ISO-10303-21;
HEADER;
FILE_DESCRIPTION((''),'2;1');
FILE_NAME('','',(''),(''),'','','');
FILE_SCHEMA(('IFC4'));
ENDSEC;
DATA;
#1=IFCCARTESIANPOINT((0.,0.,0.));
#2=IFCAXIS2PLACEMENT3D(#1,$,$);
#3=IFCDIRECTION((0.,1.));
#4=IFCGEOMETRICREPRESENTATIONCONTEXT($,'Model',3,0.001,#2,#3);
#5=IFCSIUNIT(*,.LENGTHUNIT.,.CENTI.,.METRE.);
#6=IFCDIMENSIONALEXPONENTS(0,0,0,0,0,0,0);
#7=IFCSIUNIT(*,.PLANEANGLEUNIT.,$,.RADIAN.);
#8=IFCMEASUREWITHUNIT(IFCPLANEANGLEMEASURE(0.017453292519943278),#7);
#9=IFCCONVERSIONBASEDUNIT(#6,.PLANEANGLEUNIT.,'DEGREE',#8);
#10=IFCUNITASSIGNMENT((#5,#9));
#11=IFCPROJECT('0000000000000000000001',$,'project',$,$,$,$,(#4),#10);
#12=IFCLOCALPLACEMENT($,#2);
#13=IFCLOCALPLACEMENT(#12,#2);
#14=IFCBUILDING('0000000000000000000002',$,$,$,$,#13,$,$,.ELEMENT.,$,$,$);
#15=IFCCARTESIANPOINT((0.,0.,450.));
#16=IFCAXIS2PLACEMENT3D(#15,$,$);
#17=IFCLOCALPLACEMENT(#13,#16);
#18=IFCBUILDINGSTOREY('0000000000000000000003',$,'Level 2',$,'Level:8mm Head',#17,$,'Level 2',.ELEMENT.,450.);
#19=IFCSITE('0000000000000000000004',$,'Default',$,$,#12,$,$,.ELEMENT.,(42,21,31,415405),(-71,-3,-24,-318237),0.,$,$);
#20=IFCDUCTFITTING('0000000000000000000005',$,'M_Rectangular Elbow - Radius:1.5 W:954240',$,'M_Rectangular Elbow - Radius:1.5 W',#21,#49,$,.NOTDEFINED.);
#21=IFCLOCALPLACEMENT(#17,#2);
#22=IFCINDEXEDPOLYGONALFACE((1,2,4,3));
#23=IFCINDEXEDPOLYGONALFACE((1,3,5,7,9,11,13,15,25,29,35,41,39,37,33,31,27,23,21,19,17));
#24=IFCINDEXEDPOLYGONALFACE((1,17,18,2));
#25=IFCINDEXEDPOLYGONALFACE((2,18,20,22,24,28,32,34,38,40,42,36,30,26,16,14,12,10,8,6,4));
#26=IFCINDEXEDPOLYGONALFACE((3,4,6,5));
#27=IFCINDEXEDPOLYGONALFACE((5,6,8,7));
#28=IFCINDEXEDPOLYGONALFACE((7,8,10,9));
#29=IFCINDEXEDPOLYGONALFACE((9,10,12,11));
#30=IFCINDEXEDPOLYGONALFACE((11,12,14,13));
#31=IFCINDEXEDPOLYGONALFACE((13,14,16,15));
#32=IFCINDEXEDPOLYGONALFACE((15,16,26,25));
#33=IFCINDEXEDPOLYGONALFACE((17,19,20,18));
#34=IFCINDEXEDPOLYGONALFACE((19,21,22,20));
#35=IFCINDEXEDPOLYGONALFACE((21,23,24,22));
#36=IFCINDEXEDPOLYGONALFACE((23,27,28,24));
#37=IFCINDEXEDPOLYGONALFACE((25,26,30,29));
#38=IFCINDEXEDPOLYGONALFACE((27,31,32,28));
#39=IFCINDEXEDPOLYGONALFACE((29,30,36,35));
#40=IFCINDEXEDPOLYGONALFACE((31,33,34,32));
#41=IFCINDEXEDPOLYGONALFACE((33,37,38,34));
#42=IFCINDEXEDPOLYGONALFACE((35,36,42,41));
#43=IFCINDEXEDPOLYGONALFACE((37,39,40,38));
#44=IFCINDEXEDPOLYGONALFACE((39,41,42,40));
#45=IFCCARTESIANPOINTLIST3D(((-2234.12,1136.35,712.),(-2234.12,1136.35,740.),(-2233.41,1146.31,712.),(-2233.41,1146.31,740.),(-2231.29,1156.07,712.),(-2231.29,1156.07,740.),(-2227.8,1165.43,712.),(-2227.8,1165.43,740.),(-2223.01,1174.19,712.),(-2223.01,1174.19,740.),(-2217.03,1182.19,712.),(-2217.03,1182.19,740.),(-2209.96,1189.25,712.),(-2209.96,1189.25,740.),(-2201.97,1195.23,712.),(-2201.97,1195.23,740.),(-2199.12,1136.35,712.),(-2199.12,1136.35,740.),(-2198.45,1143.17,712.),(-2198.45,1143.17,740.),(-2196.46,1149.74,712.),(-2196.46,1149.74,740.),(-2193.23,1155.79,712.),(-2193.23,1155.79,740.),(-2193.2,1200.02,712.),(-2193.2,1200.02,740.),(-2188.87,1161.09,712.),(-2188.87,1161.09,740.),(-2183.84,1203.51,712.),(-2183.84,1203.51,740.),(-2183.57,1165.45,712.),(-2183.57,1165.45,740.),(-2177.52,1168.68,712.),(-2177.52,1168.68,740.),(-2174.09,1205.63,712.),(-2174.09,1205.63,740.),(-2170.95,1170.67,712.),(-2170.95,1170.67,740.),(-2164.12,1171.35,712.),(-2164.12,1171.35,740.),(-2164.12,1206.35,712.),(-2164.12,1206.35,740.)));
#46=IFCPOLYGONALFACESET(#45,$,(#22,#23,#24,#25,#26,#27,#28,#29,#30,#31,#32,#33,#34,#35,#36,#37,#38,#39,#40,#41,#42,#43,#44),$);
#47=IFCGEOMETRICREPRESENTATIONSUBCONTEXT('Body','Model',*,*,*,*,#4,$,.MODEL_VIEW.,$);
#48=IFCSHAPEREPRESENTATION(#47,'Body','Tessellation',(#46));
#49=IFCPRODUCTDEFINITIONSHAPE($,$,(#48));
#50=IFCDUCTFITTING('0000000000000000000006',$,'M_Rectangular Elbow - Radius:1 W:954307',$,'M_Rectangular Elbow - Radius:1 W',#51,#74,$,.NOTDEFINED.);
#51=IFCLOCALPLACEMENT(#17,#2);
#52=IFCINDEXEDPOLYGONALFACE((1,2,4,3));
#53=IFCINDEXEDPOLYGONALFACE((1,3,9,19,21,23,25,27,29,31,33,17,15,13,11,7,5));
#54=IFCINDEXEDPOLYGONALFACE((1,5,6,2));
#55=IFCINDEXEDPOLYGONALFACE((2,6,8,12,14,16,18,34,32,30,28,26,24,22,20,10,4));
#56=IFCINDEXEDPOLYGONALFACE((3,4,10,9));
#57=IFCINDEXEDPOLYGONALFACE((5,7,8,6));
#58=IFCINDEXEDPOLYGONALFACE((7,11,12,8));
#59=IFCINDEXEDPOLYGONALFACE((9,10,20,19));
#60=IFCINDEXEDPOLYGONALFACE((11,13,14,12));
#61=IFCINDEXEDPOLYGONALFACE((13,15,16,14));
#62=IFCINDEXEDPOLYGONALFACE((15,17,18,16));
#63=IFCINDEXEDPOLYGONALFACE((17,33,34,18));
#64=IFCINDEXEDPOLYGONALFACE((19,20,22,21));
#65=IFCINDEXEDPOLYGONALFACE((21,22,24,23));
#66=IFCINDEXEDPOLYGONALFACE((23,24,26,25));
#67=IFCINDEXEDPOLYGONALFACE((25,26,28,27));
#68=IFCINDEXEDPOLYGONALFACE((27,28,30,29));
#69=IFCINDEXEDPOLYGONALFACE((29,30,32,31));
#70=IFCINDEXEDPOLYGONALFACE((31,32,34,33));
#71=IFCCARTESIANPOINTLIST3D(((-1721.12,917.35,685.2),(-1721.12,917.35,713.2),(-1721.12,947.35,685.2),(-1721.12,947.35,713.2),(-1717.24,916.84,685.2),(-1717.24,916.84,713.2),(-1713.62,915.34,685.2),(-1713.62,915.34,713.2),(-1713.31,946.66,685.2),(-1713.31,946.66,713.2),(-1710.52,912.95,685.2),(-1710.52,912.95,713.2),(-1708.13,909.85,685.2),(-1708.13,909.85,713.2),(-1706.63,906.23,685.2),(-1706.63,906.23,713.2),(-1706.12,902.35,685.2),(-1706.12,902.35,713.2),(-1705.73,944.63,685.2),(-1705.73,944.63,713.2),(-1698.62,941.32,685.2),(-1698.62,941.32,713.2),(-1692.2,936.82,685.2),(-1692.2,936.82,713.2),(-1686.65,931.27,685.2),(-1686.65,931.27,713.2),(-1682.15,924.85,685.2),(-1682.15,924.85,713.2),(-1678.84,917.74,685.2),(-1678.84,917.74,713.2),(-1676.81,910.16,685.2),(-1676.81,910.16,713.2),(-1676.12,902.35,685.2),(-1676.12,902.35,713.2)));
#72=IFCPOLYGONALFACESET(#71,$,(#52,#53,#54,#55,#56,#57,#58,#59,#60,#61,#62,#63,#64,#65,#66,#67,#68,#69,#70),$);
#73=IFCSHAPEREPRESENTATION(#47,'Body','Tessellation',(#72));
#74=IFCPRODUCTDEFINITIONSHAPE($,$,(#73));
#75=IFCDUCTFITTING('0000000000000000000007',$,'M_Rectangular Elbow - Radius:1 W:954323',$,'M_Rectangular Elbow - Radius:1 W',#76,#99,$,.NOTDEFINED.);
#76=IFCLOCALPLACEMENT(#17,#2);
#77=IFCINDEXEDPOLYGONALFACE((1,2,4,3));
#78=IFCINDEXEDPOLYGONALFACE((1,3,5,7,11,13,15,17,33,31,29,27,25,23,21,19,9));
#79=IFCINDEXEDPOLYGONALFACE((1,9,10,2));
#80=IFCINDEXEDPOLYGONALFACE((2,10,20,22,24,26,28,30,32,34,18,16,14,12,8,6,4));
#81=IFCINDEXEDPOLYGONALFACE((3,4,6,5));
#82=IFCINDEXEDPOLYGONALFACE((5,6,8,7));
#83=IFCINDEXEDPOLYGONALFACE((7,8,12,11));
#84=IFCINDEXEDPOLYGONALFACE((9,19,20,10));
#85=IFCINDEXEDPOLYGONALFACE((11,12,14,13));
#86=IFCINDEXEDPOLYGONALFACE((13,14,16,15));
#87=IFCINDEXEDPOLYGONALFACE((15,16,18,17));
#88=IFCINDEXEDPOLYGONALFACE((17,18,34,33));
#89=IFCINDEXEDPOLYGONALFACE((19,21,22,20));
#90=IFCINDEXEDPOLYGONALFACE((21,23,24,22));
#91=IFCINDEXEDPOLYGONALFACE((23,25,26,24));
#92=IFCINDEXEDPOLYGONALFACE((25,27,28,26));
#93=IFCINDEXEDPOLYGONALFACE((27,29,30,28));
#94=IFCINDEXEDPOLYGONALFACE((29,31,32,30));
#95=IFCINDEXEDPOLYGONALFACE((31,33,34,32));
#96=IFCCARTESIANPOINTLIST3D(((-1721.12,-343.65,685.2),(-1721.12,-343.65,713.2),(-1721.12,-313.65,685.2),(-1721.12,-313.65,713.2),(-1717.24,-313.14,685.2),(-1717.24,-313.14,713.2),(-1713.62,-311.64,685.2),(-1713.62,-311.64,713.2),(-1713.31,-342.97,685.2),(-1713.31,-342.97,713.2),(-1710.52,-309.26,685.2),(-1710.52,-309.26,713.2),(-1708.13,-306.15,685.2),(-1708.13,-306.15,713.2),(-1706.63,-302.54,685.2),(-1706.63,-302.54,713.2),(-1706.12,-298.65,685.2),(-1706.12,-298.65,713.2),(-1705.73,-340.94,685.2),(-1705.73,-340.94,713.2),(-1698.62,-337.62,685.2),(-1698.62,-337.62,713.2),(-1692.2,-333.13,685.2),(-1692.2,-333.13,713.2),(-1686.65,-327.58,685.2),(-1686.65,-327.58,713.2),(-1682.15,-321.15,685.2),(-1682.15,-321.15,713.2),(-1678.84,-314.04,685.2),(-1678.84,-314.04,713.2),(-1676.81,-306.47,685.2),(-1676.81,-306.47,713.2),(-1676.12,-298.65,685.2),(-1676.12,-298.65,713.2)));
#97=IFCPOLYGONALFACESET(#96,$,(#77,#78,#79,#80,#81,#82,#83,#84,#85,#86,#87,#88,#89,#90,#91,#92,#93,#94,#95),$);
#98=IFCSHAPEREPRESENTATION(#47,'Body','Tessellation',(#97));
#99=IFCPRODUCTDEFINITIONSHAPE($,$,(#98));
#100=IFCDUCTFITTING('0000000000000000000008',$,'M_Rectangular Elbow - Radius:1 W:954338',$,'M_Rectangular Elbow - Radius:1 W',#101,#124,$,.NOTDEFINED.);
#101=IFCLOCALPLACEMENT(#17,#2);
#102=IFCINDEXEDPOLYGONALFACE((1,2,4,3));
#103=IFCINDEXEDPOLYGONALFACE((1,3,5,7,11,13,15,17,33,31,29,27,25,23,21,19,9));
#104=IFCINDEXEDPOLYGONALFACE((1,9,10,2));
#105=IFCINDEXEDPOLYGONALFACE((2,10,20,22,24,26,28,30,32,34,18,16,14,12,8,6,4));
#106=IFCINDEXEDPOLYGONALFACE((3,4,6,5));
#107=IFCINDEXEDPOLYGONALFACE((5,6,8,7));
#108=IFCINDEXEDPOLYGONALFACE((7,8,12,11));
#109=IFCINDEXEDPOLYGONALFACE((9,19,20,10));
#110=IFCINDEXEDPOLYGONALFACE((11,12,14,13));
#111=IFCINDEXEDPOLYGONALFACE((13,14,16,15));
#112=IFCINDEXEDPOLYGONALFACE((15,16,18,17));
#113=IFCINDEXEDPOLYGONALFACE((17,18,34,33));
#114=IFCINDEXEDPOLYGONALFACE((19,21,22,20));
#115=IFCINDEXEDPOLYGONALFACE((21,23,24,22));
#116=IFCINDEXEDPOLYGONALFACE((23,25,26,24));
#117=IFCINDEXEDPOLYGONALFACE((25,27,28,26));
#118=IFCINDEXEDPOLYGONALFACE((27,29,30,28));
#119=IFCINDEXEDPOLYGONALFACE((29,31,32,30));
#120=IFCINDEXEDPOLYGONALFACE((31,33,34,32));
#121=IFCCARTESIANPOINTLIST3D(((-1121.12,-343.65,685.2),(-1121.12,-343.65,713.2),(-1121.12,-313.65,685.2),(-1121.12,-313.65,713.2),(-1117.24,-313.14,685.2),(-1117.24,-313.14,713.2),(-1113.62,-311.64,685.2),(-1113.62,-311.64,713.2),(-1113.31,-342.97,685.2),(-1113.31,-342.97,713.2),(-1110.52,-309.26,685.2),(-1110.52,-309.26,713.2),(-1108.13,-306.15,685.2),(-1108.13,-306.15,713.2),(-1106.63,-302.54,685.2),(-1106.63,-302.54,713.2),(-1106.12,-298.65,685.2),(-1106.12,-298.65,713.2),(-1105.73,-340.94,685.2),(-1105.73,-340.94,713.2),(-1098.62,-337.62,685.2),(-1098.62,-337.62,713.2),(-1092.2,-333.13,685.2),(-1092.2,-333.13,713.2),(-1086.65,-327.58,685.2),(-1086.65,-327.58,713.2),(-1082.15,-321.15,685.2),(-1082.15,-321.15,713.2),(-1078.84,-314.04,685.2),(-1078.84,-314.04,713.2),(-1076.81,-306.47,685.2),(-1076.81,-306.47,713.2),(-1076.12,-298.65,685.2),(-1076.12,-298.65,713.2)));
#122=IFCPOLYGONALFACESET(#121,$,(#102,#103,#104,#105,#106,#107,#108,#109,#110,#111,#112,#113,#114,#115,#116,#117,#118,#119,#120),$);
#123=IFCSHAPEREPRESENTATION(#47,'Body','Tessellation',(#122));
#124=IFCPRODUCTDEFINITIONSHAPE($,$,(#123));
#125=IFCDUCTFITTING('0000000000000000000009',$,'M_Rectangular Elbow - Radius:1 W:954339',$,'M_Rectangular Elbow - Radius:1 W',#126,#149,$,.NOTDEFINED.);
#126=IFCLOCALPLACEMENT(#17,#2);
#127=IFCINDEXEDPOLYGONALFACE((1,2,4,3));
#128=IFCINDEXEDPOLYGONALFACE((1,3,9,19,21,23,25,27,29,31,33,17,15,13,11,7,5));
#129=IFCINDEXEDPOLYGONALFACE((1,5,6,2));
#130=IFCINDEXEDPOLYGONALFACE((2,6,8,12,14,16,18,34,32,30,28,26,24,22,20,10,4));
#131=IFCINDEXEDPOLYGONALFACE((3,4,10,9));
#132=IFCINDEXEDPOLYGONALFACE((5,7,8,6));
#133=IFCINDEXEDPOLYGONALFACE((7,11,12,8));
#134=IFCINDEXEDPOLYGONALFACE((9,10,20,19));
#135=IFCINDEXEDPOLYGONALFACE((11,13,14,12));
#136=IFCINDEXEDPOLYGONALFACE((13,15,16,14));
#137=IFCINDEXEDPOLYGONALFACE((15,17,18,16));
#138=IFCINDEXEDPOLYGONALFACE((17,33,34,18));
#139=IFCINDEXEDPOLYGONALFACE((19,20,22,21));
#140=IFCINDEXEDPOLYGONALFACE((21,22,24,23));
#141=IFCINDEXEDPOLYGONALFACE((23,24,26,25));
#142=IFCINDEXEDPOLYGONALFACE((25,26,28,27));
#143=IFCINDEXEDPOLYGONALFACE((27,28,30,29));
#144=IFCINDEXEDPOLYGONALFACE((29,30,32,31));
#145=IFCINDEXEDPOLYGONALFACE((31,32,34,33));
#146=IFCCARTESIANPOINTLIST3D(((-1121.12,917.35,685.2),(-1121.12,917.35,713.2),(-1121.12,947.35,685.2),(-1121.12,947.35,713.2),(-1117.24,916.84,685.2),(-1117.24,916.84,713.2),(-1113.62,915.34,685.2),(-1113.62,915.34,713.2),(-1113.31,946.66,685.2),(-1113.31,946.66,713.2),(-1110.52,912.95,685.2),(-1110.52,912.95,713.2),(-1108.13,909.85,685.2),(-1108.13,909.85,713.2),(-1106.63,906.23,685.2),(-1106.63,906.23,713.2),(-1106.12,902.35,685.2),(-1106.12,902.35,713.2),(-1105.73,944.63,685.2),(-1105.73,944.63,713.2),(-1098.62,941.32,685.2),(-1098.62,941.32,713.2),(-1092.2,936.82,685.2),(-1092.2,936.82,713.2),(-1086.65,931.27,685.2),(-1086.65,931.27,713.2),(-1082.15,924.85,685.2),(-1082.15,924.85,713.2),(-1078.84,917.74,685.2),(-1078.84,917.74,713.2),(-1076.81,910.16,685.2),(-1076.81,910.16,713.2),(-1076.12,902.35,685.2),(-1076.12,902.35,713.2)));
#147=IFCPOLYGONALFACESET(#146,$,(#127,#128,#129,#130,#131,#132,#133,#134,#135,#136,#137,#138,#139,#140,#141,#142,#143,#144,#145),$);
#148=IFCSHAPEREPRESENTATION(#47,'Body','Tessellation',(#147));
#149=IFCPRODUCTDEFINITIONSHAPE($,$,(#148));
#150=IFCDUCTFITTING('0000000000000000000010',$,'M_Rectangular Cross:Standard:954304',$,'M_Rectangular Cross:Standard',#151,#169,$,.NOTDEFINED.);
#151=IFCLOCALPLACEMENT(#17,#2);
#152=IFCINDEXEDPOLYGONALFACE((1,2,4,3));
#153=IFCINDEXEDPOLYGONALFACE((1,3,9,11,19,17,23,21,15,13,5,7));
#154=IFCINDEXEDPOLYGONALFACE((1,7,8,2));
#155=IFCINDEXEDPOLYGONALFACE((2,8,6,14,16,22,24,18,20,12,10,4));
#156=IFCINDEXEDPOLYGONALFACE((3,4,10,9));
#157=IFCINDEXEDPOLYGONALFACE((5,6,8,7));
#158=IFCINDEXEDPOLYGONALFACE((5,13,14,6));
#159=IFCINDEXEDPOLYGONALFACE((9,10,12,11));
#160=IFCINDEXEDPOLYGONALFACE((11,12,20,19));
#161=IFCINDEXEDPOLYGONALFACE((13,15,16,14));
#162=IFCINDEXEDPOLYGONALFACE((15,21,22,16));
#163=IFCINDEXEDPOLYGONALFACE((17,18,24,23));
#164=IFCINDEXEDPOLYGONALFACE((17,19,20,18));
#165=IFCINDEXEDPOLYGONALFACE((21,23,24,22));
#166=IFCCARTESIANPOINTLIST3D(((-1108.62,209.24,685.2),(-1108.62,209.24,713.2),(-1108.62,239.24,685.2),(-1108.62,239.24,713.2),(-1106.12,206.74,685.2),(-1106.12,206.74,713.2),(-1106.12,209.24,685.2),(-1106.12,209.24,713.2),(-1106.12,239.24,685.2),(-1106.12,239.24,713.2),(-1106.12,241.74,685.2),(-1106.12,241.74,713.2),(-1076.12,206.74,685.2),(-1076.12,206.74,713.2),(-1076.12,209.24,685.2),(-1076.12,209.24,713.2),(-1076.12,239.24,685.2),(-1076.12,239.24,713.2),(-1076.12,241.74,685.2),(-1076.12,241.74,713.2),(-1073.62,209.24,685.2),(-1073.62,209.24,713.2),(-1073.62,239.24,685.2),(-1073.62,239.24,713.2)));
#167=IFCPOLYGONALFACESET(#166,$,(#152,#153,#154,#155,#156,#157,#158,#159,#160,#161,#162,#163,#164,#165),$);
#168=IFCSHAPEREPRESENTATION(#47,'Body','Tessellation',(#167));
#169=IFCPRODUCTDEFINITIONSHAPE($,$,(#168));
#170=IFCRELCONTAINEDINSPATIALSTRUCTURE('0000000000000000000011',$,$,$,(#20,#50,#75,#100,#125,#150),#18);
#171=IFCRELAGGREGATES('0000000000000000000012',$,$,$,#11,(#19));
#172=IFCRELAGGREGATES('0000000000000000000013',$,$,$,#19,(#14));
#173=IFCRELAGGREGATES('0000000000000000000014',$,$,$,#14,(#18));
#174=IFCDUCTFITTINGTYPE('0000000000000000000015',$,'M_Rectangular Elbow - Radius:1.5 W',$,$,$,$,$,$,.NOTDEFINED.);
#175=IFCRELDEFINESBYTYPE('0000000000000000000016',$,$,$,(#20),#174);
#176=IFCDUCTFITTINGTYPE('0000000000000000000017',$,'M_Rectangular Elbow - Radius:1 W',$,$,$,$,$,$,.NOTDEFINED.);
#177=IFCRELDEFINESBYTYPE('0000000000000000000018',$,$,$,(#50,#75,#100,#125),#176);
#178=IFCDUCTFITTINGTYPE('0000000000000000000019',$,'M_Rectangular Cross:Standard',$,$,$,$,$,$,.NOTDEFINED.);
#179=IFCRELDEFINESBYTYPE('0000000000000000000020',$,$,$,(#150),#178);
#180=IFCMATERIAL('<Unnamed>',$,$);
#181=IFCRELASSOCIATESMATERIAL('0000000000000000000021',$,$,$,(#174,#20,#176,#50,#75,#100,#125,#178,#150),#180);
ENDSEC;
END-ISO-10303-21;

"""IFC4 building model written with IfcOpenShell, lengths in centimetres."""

from ifc_helpers import new_model, entity, si_unit, converted_unit, direction, frame, origin, place, context, subcontext, project, spatial, line, arc, indexed_curve, outline, extrude, source, transform, mapped, material, type_object, type_shapes, element, save


model = new_model("IFC4")

# Units and contexts
model_context = context("Model", 3, precision=0.001, world=origin(), true_north=direction((0.0, 1.0)))
body_context = subcontext(model_context, "Body", "Model", "MODEL_VIEW")
ifc_project = project(units=[si_unit("LENGTHUNIT", "METRE", prefix="CENTI"), converted_unit("PLANEANGLEUNIT", "DEGREE", entity("IfcPlaneAngleMeasure", 0.017453292519943278), si_unit("PLANEANGLEUNIT", "RADIAN"), dimensions=[0, 0, 0, 0, 0, 0, 0])], contexts=[model_context])

# Site, building, storey
site_placement = place(None, origin())
site = spatial("IfcSite", under=ifc_project, at=site_placement, Name="Default", CompositionType="ELEMENT", RefLatitude=(42, 21, 31, 415405), RefLongitude=(-71, -3, -24, -318237), RefElevation=0.0)
building_placement = place(site_placement, origin())
building = spatial("IfcBuilding", under=site, at=building_placement, CompositionType="ELEMENT")
storey_placement = place(building_placement, frame((0.0, 0.0, 450.0)))
storey = spatial("IfcBuildingStorey", under=building, at=storey_placement, Name="Level 2", ObjectType="Level:8mm Head", LongName="Level 2", CompositionType="ELEMENT", Elevation=450.0)

# Duct fittings
ifc_material = material(Name="<Unnamed>")
duct_fitting_type_1 = type_object("IfcDuctFittingType", Name="M_Rectangular Elbow - Radius:1.5 W", PredefinedType="NOTDEFINED", material=ifc_material)
shared_shape_1 = source(origin(), body_context, "Body", "SweptSolid", [
    extrude(outline(indexed_curve([(-43.75, -26.25), (-8.75, -26.25), (1.5, -1.5), (26.25, 8.75), (26.25, 43.75), (-23.25, 23.25)], segments=[line(1, 2), arc(2, 3, 4), line(4, 5), arc(5, 6, 1)], self_intersect=False)), frame((-26.25, 26.25, -14.0), z_axis=(0.0, 0.0, 1.0), x_axis=(-1.0, 0.0, 0.0)), (0.0, 0.0, 1.0), 28.0),
])
type_shapes(duct_fitting_type_1, [shared_shape_1])
for number, where, z_axis, x_axis, name in (
    (1, (-2216.62, 1188.85, 726.0), (0.0, 0.0, 1.0), (-1.0, 0.0, 0.0), "M_Rectangular Elbow - Radius:1.5 W:954240"),
):
    element("IfcDuctFitting", number, at=place(storey_placement, frame(where, z_axis=z_axis, x_axis=x_axis)), inside=storey, type_object=duct_fitting_type_1, material=ifc_material, Name=name, ObjectType="M_Rectangular Elbow - Radius:1.5 W", PredefinedType="NOTDEFINED", context=body_context, shape_type="MappedRepresentation", body=[
        mapped(shared_shape_1, transform((0.0, 0.0, 0.0), scale=1.0)),
    ])
duct_fitting_type_2 = type_object("IfcDuctFittingType", Name="M_Rectangular Elbow - Radius:1 W", PredefinedType="NOTDEFINED", material=ifc_material)
shared_shape_2 = source(origin(), body_context, "Body", "SweptSolid", [
    extrude(outline(indexed_curve([(-30.0, -15.0), (0.0, -15.0), (4.39, -4.39), (15.0, 0.0), (15.0, 30.0), (-16.82, 16.82)], segments=[line(1, 2), arc(2, 3, 4), line(4, 5), arc(5, 6, 1)], self_intersect=False)), frame((-15.0, 15.0, -14.0), z_axis=(0.0, 0.0, 1.0), x_axis=(-1.0, 0.0, 0.0)), (0.0, 0.0, 1.0), 28.0),
])
type_shapes(duct_fitting_type_2, [shared_shape_2])
duct_fitting_1_placement = place(storey_placement, frame((-1691.12, 932.35, 699.2), z_axis=(0.0, 0.0, 1.0), x_axis=(0.0, 1.0, 0.0)))
element("IfcDuctFitting", 2, at=duct_fitting_1_placement, inside=storey, type_object=duct_fitting_type_2, material=ifc_material, Name="M_Rectangular Elbow - Radius:1 W:954307", ObjectType="M_Rectangular Elbow - Radius:1 W", PredefinedType="NOTDEFINED", context=body_context, shape_type="MappedRepresentation", body=[
    mapped(shared_shape_2, transform((0.0, 0.0, 0.0), scale=1.0)),
])
for number, where, name in (
    (3, (-1691.12, -328.65, 699.2), "M_Rectangular Elbow - Radius:1 W:954323"),
    (4, (-1091.12, -328.65, 699.2), "M_Rectangular Elbow - Radius:1 W:954338"),
):
    element("IfcDuctFitting", number, at=place(storey_placement, frame(where)), inside=storey, type_object=duct_fitting_type_2, material=ifc_material, Name=name, ObjectType="M_Rectangular Elbow - Radius:1 W", PredefinedType="NOTDEFINED", context=body_context, shape_type="MappedRepresentation", body=[
        mapped(shared_shape_2, transform((0.0, 0.0, 0.0), scale=1.0)),
    ])
duct_fitting_2_placement = place(storey_placement, frame((-1091.12, 932.35, 699.2), z_axis=(0.0, 0.0, 1.0), x_axis=(0.0, 1.0, 0.0)))
element("IfcDuctFitting", 5, at=duct_fitting_2_placement, inside=storey, type_object=duct_fitting_type_2, material=ifc_material, Name="M_Rectangular Elbow - Radius:1 W:954339", ObjectType="M_Rectangular Elbow - Radius:1 W", PredefinedType="NOTDEFINED", context=body_context, shape_type="MappedRepresentation", body=[
    mapped(shared_shape_2, transform((0.0, 0.0, 0.0), scale=1.0)),
])
duct_fitting_type_3 = type_object("IfcDuctFittingType", Name="M_Rectangular Cross:Standard", PredefinedType="NOTDEFINED", material=ifc_material)
shared_shape_3 = source(origin(), body_context, "Body", "SweptSolid", [
    extrude(outline(indexed_curve([(-17.5, 15.0), (-17.5, -15.0), (-15.0, -15.0), (-15.0, -17.5), (15.0, -17.5), (15.0, -15.0), (17.5, -15.0), (17.5, 15.0), (15.0, 15.0), (15.0, 17.5), (-15.0, 17.5), (-15.0, 15.0), (-17.5, 15.0)], self_intersect=False)), frame((0.0, 0.0, -14.0), z_axis=(0.0, 0.0, -1.0), x_axis=(0.0, 1.0, 0.0)), (0.0, 0.0, -1.0), 28.0),
])
type_shapes(duct_fitting_type_3, [shared_shape_3])
duct_fitting_3_placement = place(storey_placement, frame((-1091.12, 224.24, 699.2)))
element("IfcDuctFitting", 6, at=duct_fitting_3_placement, inside=storey, type_object=duct_fitting_type_3, material=ifc_material, Name="M_Rectangular Cross:Standard:954304", ObjectType="M_Rectangular Cross:Standard", PredefinedType="NOTDEFINED", context=body_context, shape_type="MappedRepresentation", body=[
    mapped(shared_shape_3, transform((0.0, 0.0, 0.0), scale=1.0)),
])

save(model, "model.ifc")
